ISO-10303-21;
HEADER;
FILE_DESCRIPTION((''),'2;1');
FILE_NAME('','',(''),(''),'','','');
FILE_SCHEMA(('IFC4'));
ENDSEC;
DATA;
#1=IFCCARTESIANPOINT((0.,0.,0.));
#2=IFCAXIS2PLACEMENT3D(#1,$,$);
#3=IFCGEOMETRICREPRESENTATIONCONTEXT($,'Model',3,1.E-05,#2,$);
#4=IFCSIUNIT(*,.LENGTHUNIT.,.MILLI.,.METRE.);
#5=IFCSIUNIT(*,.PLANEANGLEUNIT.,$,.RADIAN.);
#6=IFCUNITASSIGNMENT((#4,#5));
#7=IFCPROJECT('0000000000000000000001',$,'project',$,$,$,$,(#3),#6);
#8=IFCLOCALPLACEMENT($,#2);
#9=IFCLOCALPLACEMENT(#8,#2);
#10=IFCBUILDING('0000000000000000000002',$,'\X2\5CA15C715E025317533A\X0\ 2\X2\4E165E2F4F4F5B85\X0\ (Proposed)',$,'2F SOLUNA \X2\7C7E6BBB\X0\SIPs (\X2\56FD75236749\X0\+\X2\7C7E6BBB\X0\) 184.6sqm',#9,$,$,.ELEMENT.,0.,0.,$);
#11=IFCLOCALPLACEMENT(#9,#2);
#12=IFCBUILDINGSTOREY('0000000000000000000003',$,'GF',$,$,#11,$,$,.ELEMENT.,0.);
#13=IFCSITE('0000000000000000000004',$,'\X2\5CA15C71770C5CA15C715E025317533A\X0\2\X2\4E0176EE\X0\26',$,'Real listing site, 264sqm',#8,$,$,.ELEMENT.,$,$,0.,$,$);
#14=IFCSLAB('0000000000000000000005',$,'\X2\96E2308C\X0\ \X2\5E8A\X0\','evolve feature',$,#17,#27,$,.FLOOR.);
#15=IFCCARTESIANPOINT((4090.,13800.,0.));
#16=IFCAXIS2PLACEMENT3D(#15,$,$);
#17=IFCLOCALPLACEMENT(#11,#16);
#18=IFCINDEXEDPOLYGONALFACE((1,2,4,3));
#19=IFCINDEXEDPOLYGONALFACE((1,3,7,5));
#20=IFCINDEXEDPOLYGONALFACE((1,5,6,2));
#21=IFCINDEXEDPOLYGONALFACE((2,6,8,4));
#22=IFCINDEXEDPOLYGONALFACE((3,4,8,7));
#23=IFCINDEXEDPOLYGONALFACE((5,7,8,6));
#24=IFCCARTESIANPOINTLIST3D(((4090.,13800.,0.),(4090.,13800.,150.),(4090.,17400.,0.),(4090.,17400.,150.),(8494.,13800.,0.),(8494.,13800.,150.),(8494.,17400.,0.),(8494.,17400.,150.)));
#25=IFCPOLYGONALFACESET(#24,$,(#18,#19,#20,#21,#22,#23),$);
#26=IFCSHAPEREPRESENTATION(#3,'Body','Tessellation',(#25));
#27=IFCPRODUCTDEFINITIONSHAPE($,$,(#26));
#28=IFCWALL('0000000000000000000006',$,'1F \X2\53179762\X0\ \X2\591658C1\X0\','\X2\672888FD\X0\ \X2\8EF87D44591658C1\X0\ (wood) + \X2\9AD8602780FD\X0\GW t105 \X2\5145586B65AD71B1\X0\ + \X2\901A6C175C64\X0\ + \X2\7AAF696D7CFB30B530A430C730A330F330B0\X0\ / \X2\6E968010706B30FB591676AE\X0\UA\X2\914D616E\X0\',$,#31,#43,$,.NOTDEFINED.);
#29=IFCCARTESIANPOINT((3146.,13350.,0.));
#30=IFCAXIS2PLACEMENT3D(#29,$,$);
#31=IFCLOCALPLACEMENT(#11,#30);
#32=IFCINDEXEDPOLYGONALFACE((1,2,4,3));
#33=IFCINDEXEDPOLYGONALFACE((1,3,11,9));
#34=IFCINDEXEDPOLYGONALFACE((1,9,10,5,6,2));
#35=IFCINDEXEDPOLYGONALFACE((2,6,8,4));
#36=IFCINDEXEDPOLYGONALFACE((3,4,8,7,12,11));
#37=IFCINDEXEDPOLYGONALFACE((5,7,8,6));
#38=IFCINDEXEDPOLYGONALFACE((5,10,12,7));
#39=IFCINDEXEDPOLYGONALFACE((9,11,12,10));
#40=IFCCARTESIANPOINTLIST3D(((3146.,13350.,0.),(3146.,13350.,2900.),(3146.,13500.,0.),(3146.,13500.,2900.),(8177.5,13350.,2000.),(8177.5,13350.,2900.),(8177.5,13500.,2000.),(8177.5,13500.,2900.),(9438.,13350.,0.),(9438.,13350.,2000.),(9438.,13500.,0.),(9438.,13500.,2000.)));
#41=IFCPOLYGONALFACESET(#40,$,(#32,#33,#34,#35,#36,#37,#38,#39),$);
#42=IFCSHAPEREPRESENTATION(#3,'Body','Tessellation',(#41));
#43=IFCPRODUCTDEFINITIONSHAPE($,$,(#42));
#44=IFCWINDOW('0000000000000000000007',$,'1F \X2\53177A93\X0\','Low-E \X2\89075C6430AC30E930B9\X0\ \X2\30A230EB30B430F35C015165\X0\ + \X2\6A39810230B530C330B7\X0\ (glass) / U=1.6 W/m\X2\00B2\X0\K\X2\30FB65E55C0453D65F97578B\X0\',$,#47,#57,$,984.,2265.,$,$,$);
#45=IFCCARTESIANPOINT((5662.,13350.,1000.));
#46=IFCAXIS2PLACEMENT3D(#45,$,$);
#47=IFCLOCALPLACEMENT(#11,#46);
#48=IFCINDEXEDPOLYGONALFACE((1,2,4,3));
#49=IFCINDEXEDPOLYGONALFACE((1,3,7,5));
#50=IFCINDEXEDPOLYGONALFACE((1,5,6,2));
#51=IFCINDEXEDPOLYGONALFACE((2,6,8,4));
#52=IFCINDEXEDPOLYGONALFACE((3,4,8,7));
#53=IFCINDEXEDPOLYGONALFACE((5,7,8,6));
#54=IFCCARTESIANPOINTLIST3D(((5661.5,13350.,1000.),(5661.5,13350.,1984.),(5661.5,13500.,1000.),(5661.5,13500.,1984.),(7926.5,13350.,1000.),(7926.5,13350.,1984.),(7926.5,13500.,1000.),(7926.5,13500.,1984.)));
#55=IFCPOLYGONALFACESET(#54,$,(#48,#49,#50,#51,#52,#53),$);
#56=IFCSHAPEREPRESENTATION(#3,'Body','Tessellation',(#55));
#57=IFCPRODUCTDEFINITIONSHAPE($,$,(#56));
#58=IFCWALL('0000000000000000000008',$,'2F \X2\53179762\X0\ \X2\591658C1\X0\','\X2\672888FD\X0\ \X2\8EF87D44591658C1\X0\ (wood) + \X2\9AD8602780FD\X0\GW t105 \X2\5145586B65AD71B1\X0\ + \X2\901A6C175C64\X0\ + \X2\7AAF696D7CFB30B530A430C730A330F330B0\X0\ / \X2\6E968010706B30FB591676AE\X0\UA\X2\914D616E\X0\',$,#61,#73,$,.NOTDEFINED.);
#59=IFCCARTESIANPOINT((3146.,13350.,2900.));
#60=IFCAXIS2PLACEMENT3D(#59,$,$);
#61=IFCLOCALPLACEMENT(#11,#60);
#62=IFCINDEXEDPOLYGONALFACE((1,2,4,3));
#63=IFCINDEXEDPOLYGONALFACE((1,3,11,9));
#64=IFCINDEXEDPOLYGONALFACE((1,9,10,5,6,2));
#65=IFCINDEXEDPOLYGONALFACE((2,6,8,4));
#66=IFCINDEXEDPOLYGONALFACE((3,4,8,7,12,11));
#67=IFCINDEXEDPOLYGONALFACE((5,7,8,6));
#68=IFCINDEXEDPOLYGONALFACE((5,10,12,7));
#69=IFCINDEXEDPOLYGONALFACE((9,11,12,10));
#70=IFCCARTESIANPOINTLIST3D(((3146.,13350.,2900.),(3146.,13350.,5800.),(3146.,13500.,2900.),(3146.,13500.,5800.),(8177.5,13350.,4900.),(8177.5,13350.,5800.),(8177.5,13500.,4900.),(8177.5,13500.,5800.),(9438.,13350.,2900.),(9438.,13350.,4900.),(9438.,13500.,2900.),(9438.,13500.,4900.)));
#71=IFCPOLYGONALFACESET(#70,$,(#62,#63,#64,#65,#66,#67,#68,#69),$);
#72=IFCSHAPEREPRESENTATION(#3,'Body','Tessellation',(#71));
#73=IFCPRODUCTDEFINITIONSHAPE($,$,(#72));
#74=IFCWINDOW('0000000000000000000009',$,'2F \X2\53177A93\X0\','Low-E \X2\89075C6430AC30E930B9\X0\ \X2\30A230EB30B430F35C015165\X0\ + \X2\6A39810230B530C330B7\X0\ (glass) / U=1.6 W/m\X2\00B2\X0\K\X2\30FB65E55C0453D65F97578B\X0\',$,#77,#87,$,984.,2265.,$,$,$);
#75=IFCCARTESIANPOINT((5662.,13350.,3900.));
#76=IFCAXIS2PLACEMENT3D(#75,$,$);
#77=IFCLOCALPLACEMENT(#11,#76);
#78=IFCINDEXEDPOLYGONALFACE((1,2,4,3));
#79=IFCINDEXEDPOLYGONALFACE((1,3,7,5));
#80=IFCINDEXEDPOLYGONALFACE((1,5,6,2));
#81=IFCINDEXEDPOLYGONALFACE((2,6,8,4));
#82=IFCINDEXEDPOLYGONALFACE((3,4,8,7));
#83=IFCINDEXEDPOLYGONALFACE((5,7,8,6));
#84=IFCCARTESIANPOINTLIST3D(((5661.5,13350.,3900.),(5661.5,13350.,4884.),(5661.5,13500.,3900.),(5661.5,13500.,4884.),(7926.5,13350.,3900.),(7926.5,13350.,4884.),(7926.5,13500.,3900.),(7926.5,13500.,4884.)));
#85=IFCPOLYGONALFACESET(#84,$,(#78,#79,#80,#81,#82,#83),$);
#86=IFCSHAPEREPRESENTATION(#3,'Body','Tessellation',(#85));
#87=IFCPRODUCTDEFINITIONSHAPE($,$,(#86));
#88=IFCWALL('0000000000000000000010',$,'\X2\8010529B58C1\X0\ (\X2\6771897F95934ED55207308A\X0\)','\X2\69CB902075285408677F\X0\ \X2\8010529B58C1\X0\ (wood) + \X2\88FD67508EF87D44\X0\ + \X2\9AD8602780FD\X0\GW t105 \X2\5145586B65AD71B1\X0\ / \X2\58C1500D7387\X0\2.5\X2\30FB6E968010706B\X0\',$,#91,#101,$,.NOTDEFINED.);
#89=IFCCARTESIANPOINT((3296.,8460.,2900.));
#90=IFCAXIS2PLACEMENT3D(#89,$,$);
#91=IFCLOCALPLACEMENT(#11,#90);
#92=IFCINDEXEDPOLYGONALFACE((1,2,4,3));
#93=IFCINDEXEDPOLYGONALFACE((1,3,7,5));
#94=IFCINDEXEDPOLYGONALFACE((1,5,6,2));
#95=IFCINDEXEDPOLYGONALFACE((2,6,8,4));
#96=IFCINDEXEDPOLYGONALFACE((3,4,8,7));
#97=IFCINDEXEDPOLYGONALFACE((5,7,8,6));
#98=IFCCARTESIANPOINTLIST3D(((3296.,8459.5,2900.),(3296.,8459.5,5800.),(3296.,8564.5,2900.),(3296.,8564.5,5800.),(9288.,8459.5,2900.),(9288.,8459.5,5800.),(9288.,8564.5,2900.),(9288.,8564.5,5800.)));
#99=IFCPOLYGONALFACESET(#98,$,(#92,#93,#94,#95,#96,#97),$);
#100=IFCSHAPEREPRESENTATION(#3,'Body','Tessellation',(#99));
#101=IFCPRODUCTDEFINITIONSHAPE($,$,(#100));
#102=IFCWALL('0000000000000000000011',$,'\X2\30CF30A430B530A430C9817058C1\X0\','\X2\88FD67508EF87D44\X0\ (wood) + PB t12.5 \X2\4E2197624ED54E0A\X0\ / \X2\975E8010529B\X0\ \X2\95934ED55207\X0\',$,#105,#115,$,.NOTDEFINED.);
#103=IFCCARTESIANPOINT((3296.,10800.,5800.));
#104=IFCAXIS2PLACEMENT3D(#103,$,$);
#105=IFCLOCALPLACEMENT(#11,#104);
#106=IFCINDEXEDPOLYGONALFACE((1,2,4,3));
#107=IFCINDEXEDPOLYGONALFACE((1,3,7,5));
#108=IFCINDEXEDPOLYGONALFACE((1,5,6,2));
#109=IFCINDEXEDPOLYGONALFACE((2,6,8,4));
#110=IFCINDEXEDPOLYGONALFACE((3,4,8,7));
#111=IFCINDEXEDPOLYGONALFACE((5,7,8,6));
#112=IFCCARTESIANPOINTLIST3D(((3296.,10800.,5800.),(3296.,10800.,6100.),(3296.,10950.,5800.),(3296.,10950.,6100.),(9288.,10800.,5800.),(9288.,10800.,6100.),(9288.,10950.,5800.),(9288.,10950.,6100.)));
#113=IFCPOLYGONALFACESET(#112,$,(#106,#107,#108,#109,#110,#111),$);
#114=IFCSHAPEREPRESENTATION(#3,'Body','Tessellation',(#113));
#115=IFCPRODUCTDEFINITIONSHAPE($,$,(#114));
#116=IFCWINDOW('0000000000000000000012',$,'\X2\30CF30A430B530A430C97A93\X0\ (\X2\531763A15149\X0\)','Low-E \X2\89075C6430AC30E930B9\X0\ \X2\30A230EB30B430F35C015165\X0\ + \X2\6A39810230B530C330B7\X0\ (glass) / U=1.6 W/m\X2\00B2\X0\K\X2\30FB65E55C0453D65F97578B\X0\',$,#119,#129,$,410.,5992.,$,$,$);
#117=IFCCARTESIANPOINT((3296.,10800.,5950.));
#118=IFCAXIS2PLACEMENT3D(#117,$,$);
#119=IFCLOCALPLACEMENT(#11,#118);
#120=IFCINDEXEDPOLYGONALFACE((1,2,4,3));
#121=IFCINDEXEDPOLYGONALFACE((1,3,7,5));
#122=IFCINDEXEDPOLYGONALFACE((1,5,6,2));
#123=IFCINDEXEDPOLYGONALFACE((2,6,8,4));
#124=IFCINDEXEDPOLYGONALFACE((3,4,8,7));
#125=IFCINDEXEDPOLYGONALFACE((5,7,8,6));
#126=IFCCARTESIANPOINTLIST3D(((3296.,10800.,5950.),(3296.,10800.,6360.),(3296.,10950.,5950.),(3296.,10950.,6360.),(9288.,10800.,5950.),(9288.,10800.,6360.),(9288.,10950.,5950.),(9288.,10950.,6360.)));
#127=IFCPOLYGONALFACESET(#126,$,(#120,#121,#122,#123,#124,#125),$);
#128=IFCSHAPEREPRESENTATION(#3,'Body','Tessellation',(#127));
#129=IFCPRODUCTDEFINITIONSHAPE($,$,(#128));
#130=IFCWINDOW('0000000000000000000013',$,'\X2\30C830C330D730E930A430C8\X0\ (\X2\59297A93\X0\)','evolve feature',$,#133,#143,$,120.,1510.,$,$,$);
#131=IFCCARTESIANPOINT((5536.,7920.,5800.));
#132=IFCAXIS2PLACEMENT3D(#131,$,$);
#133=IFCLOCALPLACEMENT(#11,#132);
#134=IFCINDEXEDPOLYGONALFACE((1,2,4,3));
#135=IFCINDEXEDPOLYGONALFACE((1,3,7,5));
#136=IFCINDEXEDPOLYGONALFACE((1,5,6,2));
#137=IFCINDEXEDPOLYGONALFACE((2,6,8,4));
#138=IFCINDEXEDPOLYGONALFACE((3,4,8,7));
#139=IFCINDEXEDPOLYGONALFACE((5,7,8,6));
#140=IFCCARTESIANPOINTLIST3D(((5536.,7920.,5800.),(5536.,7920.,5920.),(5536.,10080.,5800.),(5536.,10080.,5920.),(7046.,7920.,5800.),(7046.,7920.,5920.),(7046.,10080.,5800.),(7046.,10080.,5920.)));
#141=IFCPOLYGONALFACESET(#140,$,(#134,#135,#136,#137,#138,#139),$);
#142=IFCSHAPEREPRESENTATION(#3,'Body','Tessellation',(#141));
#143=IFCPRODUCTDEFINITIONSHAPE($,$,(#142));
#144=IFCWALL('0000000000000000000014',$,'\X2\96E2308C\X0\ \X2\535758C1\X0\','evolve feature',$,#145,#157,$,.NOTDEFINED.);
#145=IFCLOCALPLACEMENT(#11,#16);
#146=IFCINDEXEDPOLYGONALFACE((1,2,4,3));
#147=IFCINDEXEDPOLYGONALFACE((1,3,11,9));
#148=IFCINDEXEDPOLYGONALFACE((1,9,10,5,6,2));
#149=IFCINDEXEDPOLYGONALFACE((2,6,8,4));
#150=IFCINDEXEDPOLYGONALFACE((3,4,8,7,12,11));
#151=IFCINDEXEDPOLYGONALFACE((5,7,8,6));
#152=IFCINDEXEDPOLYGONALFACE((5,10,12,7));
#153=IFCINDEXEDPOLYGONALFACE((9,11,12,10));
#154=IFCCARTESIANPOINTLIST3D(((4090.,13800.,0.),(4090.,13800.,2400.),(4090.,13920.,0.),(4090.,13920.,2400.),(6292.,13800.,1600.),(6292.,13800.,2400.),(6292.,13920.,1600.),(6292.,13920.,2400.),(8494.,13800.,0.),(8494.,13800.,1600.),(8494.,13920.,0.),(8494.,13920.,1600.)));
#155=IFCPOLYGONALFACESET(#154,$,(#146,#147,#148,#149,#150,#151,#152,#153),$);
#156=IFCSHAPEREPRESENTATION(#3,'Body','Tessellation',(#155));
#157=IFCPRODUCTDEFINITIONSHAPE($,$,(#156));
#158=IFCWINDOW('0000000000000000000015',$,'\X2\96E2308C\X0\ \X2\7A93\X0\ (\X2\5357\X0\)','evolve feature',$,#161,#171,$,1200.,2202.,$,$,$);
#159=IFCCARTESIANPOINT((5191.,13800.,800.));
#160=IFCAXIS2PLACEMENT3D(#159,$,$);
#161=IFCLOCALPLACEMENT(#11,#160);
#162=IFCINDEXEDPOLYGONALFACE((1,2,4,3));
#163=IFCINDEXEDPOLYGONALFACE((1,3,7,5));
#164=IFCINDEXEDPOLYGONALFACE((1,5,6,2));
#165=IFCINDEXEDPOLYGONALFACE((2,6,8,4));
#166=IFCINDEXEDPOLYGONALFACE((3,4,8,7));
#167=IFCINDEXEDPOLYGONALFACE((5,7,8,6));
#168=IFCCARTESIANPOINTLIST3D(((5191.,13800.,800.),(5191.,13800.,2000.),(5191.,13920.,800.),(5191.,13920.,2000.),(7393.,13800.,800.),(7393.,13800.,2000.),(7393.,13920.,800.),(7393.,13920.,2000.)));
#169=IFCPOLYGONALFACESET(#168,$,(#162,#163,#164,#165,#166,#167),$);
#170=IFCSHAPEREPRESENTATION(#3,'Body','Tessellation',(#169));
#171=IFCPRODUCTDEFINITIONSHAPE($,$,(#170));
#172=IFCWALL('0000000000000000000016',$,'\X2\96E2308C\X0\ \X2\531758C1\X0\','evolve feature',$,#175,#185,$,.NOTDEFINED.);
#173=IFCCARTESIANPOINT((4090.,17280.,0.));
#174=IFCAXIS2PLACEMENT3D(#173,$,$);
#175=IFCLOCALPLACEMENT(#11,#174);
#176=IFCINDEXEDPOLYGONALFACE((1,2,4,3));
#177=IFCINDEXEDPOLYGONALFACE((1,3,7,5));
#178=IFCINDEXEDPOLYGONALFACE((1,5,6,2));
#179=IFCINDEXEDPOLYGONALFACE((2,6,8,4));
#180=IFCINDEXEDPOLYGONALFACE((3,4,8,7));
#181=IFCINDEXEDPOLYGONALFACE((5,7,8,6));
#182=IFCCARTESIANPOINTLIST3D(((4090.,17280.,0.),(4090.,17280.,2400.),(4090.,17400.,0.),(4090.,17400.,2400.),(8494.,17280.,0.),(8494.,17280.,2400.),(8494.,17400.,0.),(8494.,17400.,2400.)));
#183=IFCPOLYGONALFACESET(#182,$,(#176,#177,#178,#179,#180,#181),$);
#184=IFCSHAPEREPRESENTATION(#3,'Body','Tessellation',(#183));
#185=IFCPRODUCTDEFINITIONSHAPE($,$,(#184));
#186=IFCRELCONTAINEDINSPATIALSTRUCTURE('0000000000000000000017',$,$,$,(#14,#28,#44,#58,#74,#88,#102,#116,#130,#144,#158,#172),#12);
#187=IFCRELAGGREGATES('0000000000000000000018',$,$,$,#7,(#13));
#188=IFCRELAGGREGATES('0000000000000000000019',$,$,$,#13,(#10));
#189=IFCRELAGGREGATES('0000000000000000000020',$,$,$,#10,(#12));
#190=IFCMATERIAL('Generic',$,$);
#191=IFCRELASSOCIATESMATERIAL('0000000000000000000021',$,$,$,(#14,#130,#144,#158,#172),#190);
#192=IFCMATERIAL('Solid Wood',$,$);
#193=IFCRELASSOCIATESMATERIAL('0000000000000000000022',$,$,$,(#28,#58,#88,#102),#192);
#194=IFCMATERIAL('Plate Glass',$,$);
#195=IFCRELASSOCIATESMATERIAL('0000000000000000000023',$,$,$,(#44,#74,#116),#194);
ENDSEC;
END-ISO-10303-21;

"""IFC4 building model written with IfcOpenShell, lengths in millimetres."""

from ifc_helpers import new_model, si_unit, frame, frame_2d, origin, place, context, project, spatial, rectangle, extrude, material, element, fill, save


model = new_model("IFC4")

# Units and contexts
model_context = context("Model", 3, precision=1e-05, world=origin())
ifc_project = project(units=[si_unit("LENGTHUNIT", "METRE", prefix="MILLI"), si_unit("PLANEANGLEUNIT", "RADIAN")], contexts=[model_context])

# Site, building, storey
site_placement = place(None, origin())
site = spatial("IfcSite", under=ifc_project, at=site_placement, Name="岡山県岡山市北区2丁目26", ObjectType="Real listing site, 264sqm", CompositionType="ELEMENT", RefElevation=0.0)
building_placement = place(site_placement, origin())
building = spatial("IfcBuilding", under=site, at=building_placement, Name="岡山市北区 2世帯住宅 (Proposed)", ObjectType="2F SOLUNA 籾殻SIPs (国産杉+籾殻) 184.6sqm", CompositionType="ELEMENT", ElevationOfRefHeight=0.0, ElevationOfTerrain=0.0)
storey_placement = place(building_placement, origin())
storey = spatial("IfcBuildingStorey", under=building, at=storey_placement, Name="GF", CompositionType="ELEMENT", Elevation=0.0)

# Slab
ifc_material_1 = material(Name="Generic")
slab_placement = place(storey_placement, frame((4090.0, 13800.0, 0.0)))
element("IfcSlab", 1, at=slab_placement, inside=storey, material=ifc_material_1, Name="離れ 床", Description="evolve feature", PredefinedType="FLOOR", context=model_context, shape_type="SweptSolid", body=[
    extrude(rectangle(XDim=4404.0, YDim=3600.0, at=frame_2d((2202.0, 1800.0))), frame((4090.0, 13800.0, 0.0)), (0.0, 0.0, 1.0), 150.0),
])

# Wall, opening, window
ifc_material_2 = material(Name="Solid Wood")
wall_1_placement = place(storey_placement, frame((3146.0, 13350.0, 0.0)))
wall_1 = element("IfcWall", 2, at=wall_1_placement, inside=storey, material=ifc_material_2, Name="1F 北面 外壁", Description="木製 軸組外壁 (wood) + 高性能GW t105 充填断熱 + 通気層 + 窯業系サイディング / 準耐火・外皮UA配慮", PredefinedType="NOTDEFINED", context=model_context, shape_type="SweptSolid", body=[
    extrude(rectangle(XDim=6292.0, YDim=150.0, at=frame_2d((3146.0, 75.0))), frame((3146.0, 13350.0, 0.0)), (0.0, 0.0, 1.0), 2900.0),
])
opening_1_placement = place(storey_placement, frame((5662.0, 13350.0, 1000.0)))
opening_1 = element("IfcOpeningElement", 3, at=opening_1_placement, cuts=wall_1, PredefinedType="NOTDEFINED", context=model_context, shape_type="SweptSolid", body=[
    extrude(rectangle(XDim=2265.0, YDim=150.0, at=frame_2d((1132.0, 75.0))), frame((5662.0, 13350.0, 1000.0)), (0.0, 0.0, 1.0), 984.0),
])
ifc_material_3 = material(Name="Plate Glass")
window_1_placement = place(storey_placement, frame((5662.0, 13350.0, 1000.0)))
window_1 = element("IfcWindow", 4, at=window_1_placement, inside=storey, material=ifc_material_3, Name="1F 北窓", Description="Low-E 複層ガラス アルゴン封入 + 樹脂サッシ (glass) / U=1.6 W/m²K・日射取得型", OverallHeight=984.0, OverallWidth=2265.0, context=model_context, shape_type="SweptSolid", body=[
    extrude(rectangle(XDim=2265.0, YDim=150.0, at=frame_2d((1132.0, 75.0))), frame((5662.0, 13350.0, 1000.0)), (0.0, 0.0, 1.0), 984.0),
])
fill(opening_1, window_1)

# Wall, opening, window
wall_2_placement = place(storey_placement, frame((3146.0, 13350.0, 2900.0)))
wall_2 = element("IfcWall", 5, at=wall_2_placement, inside=storey, material=ifc_material_2, Name="2F 北面 外壁", Description="木製 軸組外壁 (wood) + 高性能GW t105 充填断熱 + 通気層 + 窯業系サイディング / 準耐火・外皮UA配慮", PredefinedType="NOTDEFINED", context=model_context, shape_type="SweptSolid", body=[
    extrude(rectangle(XDim=6292.0, YDim=150.0, at=frame_2d((3146.0, 75.0))), frame((3146.0, 13350.0, 2900.0)), (0.0, 0.0, 1.0), 2900.0),
])
opening_2_placement = place(storey_placement, frame((5662.0, 13350.0, 3900.0)))
opening_2 = element("IfcOpeningElement", 6, at=opening_2_placement, cuts=wall_2, PredefinedType="NOTDEFINED", context=model_context, shape_type="SweptSolid", body=[
    extrude(rectangle(XDim=2265.0, YDim=150.0, at=frame_2d((1132.0, 75.0))), frame((5662.0, 13350.0, 3900.0)), (0.0, 0.0, 1.0), 984.0),
])
window_2_placement = place(storey_placement, frame((5662.0, 13350.0, 3900.0)))
window_2 = element("IfcWindow", 7, at=window_2_placement, inside=storey, material=ifc_material_3, Name="2F 北窓", Description="Low-E 複層ガラス アルゴン封入 + 樹脂サッシ (glass) / U=1.6 W/m²K・日射取得型", OverallHeight=984.0, OverallWidth=2265.0, context=model_context, shape_type="SweptSolid", body=[
    extrude(rectangle(XDim=2265.0, YDim=150.0, at=frame_2d((1132.0, 75.0))), frame((5662.0, 13350.0, 3900.0)), (0.0, 0.0, 1.0), 984.0),
])
fill(opening_2, window_2)

# Wall
wall_3_placement = place(storey_placement, frame((3296.0, 8460.0, 2900.0)))
element("IfcWall", 8, at=wall_3_placement, inside=storey, material=ifc_material_2, Name="耐力壁 (東西間仕切り)", Description="構造用合板 耐力壁 (wood) + 製材軸組 + 高性能GW t105 充填断熱 / 壁倍率2.5・準耐火", PredefinedType="NOTDEFINED", context=model_context, shape_type="SweptSolid", body=[
    extrude(rectangle(XDim=5992.0, YDim=105.0, at=frame_2d((2996.0, 52.0))), frame((3296.0, 8460.0, 2900.0)), (0.0, 0.0, 1.0), 2900.0),
])

# Wall, opening, window
wall_4_placement = place(storey_placement, frame((3296.0, 10800.0, 5800.0)))
wall_4 = element("IfcWall", 9, at=wall_4_placement, inside=storey, material=ifc_material_2, Name="ハイサイド腰壁", Description="製材軸組 (wood) + PB t12.5 両面仕上 / 非耐力 間仕切", PredefinedType="NOTDEFINED", context=model_context, shape_type="SweptSolid", body=[
    extrude(rectangle(XDim=5992.0, YDim=150.0, at=frame_2d((2996.0, 75.0))), frame((3296.0, 10800.0, 5800.0)), (0.0, 0.0, 1.0), 700.0),
])
opening_3_placement = place(storey_placement, frame((3296.0, 10800.0, 5950.0)))
opening_3 = element("IfcOpeningElement", 10, at=opening_3_placement, cuts=wall_4, PredefinedType="NOTDEFINED", context=model_context, shape_type="SweptSolid", body=[
    extrude(rectangle(XDim=5992.0, YDim=150.0, at=frame_2d((2996.0, 75.0))), frame((3296.0, 10800.0, 5950.0)), (0.0, 0.0, 1.0), 410.0),
])
window_3_placement = place(storey_placement, frame((3296.0, 10800.0, 5950.0)))
window_3 = element("IfcWindow", 11, at=window_3_placement, inside=storey, material=ifc_material_3, Name="ハイサイド窓 (北採光)", Description="Low-E 複層ガラス アルゴン封入 + 樹脂サッシ (glass) / U=1.6 W/m²K・日射取得型", OverallHeight=410.0, OverallWidth=5992.0, context=model_context, shape_type="SweptSolid", body=[
    extrude(rectangle(XDim=5992.0, YDim=150.0, at=frame_2d((2996.0, 75.0))), frame((3296.0, 10800.0, 5950.0)), (0.0, 0.0, 1.0), 410.0),
])
fill(opening_3, window_3)

# Window
window_4_placement = place(storey_placement, frame((5536.0, 7920.0, 5800.0)))
element("IfcWindow", 12, at=window_4_placement, inside=storey, material=ifc_material_1, Name="トップライト (天窓)", Description="evolve feature", OverallHeight=120.0, OverallWidth=1510.0, context=model_context, shape_type="SweptSolid", body=[
    extrude(rectangle(XDim=1510.0, YDim=2160.0, at=frame_2d((755.0, 1080.0))), frame((5536.0, 7920.0, 5800.0)), (0.0, 0.0, 1.0), 120.0),
])

# Wall, opening, window
wall_5_placement = place(storey_placement, frame((4090.0, 13800.0, 0.0)))
wall_5 = element("IfcWall", 13, at=wall_5_placement, inside=storey, material=ifc_material_1, Name="離れ 南壁", Description="evolve feature", PredefinedType="NOTDEFINED", context=model_context, shape_type="SweptSolid", body=[
    extrude(rectangle(XDim=4404.0, YDim=120.0, at=frame_2d((2202.0, 60.0))), frame((4090.0, 13800.0, 0.0)), (0.0, 0.0, 1.0), 2400.0),
])
opening_4_placement = place(storey_placement, frame((5191.0, 13800.0, 800.0)))
opening_4 = element("IfcOpeningElement", 14, at=opening_4_placement, cuts=wall_5, PredefinedType="NOTDEFINED", context=model_context, shape_type="SweptSolid", body=[
    extrude(rectangle(XDim=2202.0, YDim=120.0, at=frame_2d((1101.0, 60.0))), frame((5191.0, 13800.0, 800.0)), (0.0, 0.0, 1.0), 1200.0),
])
window_5_placement = place(storey_placement, frame((5191.0, 13800.0, 800.0)))
window_5 = element("IfcWindow", 15, at=window_5_placement, inside=storey, material=ifc_material_1, Name="離れ 窓 (南)", Description="evolve feature", OverallHeight=1200.0, OverallWidth=2202.0, context=model_context, shape_type="SweptSolid", body=[
    extrude(rectangle(XDim=2202.0, YDim=120.0, at=frame_2d((1101.0, 60.0))), frame((5191.0, 13800.0, 800.0)), (0.0, 0.0, 1.0), 1200.0),
])
fill(opening_4, window_5)

# Wall
wall_6_placement = place(storey_placement, frame((4090.0, 17280.0, 0.0)))
element("IfcWall", 16, at=wall_6_placement, inside=storey, material=ifc_material_1, Name="離れ 北壁", Description="evolve feature", PredefinedType="NOTDEFINED", context=model_context, shape_type="SweptSolid", body=[
    extrude(rectangle(XDim=4404.0, YDim=120.0, at=frame_2d((2202.0, 60.0))), frame((4090.0, 17280.0, 0.0)), (0.0, 0.0, 1.0), 2400.0),
])

save(model, "model.ifc")
